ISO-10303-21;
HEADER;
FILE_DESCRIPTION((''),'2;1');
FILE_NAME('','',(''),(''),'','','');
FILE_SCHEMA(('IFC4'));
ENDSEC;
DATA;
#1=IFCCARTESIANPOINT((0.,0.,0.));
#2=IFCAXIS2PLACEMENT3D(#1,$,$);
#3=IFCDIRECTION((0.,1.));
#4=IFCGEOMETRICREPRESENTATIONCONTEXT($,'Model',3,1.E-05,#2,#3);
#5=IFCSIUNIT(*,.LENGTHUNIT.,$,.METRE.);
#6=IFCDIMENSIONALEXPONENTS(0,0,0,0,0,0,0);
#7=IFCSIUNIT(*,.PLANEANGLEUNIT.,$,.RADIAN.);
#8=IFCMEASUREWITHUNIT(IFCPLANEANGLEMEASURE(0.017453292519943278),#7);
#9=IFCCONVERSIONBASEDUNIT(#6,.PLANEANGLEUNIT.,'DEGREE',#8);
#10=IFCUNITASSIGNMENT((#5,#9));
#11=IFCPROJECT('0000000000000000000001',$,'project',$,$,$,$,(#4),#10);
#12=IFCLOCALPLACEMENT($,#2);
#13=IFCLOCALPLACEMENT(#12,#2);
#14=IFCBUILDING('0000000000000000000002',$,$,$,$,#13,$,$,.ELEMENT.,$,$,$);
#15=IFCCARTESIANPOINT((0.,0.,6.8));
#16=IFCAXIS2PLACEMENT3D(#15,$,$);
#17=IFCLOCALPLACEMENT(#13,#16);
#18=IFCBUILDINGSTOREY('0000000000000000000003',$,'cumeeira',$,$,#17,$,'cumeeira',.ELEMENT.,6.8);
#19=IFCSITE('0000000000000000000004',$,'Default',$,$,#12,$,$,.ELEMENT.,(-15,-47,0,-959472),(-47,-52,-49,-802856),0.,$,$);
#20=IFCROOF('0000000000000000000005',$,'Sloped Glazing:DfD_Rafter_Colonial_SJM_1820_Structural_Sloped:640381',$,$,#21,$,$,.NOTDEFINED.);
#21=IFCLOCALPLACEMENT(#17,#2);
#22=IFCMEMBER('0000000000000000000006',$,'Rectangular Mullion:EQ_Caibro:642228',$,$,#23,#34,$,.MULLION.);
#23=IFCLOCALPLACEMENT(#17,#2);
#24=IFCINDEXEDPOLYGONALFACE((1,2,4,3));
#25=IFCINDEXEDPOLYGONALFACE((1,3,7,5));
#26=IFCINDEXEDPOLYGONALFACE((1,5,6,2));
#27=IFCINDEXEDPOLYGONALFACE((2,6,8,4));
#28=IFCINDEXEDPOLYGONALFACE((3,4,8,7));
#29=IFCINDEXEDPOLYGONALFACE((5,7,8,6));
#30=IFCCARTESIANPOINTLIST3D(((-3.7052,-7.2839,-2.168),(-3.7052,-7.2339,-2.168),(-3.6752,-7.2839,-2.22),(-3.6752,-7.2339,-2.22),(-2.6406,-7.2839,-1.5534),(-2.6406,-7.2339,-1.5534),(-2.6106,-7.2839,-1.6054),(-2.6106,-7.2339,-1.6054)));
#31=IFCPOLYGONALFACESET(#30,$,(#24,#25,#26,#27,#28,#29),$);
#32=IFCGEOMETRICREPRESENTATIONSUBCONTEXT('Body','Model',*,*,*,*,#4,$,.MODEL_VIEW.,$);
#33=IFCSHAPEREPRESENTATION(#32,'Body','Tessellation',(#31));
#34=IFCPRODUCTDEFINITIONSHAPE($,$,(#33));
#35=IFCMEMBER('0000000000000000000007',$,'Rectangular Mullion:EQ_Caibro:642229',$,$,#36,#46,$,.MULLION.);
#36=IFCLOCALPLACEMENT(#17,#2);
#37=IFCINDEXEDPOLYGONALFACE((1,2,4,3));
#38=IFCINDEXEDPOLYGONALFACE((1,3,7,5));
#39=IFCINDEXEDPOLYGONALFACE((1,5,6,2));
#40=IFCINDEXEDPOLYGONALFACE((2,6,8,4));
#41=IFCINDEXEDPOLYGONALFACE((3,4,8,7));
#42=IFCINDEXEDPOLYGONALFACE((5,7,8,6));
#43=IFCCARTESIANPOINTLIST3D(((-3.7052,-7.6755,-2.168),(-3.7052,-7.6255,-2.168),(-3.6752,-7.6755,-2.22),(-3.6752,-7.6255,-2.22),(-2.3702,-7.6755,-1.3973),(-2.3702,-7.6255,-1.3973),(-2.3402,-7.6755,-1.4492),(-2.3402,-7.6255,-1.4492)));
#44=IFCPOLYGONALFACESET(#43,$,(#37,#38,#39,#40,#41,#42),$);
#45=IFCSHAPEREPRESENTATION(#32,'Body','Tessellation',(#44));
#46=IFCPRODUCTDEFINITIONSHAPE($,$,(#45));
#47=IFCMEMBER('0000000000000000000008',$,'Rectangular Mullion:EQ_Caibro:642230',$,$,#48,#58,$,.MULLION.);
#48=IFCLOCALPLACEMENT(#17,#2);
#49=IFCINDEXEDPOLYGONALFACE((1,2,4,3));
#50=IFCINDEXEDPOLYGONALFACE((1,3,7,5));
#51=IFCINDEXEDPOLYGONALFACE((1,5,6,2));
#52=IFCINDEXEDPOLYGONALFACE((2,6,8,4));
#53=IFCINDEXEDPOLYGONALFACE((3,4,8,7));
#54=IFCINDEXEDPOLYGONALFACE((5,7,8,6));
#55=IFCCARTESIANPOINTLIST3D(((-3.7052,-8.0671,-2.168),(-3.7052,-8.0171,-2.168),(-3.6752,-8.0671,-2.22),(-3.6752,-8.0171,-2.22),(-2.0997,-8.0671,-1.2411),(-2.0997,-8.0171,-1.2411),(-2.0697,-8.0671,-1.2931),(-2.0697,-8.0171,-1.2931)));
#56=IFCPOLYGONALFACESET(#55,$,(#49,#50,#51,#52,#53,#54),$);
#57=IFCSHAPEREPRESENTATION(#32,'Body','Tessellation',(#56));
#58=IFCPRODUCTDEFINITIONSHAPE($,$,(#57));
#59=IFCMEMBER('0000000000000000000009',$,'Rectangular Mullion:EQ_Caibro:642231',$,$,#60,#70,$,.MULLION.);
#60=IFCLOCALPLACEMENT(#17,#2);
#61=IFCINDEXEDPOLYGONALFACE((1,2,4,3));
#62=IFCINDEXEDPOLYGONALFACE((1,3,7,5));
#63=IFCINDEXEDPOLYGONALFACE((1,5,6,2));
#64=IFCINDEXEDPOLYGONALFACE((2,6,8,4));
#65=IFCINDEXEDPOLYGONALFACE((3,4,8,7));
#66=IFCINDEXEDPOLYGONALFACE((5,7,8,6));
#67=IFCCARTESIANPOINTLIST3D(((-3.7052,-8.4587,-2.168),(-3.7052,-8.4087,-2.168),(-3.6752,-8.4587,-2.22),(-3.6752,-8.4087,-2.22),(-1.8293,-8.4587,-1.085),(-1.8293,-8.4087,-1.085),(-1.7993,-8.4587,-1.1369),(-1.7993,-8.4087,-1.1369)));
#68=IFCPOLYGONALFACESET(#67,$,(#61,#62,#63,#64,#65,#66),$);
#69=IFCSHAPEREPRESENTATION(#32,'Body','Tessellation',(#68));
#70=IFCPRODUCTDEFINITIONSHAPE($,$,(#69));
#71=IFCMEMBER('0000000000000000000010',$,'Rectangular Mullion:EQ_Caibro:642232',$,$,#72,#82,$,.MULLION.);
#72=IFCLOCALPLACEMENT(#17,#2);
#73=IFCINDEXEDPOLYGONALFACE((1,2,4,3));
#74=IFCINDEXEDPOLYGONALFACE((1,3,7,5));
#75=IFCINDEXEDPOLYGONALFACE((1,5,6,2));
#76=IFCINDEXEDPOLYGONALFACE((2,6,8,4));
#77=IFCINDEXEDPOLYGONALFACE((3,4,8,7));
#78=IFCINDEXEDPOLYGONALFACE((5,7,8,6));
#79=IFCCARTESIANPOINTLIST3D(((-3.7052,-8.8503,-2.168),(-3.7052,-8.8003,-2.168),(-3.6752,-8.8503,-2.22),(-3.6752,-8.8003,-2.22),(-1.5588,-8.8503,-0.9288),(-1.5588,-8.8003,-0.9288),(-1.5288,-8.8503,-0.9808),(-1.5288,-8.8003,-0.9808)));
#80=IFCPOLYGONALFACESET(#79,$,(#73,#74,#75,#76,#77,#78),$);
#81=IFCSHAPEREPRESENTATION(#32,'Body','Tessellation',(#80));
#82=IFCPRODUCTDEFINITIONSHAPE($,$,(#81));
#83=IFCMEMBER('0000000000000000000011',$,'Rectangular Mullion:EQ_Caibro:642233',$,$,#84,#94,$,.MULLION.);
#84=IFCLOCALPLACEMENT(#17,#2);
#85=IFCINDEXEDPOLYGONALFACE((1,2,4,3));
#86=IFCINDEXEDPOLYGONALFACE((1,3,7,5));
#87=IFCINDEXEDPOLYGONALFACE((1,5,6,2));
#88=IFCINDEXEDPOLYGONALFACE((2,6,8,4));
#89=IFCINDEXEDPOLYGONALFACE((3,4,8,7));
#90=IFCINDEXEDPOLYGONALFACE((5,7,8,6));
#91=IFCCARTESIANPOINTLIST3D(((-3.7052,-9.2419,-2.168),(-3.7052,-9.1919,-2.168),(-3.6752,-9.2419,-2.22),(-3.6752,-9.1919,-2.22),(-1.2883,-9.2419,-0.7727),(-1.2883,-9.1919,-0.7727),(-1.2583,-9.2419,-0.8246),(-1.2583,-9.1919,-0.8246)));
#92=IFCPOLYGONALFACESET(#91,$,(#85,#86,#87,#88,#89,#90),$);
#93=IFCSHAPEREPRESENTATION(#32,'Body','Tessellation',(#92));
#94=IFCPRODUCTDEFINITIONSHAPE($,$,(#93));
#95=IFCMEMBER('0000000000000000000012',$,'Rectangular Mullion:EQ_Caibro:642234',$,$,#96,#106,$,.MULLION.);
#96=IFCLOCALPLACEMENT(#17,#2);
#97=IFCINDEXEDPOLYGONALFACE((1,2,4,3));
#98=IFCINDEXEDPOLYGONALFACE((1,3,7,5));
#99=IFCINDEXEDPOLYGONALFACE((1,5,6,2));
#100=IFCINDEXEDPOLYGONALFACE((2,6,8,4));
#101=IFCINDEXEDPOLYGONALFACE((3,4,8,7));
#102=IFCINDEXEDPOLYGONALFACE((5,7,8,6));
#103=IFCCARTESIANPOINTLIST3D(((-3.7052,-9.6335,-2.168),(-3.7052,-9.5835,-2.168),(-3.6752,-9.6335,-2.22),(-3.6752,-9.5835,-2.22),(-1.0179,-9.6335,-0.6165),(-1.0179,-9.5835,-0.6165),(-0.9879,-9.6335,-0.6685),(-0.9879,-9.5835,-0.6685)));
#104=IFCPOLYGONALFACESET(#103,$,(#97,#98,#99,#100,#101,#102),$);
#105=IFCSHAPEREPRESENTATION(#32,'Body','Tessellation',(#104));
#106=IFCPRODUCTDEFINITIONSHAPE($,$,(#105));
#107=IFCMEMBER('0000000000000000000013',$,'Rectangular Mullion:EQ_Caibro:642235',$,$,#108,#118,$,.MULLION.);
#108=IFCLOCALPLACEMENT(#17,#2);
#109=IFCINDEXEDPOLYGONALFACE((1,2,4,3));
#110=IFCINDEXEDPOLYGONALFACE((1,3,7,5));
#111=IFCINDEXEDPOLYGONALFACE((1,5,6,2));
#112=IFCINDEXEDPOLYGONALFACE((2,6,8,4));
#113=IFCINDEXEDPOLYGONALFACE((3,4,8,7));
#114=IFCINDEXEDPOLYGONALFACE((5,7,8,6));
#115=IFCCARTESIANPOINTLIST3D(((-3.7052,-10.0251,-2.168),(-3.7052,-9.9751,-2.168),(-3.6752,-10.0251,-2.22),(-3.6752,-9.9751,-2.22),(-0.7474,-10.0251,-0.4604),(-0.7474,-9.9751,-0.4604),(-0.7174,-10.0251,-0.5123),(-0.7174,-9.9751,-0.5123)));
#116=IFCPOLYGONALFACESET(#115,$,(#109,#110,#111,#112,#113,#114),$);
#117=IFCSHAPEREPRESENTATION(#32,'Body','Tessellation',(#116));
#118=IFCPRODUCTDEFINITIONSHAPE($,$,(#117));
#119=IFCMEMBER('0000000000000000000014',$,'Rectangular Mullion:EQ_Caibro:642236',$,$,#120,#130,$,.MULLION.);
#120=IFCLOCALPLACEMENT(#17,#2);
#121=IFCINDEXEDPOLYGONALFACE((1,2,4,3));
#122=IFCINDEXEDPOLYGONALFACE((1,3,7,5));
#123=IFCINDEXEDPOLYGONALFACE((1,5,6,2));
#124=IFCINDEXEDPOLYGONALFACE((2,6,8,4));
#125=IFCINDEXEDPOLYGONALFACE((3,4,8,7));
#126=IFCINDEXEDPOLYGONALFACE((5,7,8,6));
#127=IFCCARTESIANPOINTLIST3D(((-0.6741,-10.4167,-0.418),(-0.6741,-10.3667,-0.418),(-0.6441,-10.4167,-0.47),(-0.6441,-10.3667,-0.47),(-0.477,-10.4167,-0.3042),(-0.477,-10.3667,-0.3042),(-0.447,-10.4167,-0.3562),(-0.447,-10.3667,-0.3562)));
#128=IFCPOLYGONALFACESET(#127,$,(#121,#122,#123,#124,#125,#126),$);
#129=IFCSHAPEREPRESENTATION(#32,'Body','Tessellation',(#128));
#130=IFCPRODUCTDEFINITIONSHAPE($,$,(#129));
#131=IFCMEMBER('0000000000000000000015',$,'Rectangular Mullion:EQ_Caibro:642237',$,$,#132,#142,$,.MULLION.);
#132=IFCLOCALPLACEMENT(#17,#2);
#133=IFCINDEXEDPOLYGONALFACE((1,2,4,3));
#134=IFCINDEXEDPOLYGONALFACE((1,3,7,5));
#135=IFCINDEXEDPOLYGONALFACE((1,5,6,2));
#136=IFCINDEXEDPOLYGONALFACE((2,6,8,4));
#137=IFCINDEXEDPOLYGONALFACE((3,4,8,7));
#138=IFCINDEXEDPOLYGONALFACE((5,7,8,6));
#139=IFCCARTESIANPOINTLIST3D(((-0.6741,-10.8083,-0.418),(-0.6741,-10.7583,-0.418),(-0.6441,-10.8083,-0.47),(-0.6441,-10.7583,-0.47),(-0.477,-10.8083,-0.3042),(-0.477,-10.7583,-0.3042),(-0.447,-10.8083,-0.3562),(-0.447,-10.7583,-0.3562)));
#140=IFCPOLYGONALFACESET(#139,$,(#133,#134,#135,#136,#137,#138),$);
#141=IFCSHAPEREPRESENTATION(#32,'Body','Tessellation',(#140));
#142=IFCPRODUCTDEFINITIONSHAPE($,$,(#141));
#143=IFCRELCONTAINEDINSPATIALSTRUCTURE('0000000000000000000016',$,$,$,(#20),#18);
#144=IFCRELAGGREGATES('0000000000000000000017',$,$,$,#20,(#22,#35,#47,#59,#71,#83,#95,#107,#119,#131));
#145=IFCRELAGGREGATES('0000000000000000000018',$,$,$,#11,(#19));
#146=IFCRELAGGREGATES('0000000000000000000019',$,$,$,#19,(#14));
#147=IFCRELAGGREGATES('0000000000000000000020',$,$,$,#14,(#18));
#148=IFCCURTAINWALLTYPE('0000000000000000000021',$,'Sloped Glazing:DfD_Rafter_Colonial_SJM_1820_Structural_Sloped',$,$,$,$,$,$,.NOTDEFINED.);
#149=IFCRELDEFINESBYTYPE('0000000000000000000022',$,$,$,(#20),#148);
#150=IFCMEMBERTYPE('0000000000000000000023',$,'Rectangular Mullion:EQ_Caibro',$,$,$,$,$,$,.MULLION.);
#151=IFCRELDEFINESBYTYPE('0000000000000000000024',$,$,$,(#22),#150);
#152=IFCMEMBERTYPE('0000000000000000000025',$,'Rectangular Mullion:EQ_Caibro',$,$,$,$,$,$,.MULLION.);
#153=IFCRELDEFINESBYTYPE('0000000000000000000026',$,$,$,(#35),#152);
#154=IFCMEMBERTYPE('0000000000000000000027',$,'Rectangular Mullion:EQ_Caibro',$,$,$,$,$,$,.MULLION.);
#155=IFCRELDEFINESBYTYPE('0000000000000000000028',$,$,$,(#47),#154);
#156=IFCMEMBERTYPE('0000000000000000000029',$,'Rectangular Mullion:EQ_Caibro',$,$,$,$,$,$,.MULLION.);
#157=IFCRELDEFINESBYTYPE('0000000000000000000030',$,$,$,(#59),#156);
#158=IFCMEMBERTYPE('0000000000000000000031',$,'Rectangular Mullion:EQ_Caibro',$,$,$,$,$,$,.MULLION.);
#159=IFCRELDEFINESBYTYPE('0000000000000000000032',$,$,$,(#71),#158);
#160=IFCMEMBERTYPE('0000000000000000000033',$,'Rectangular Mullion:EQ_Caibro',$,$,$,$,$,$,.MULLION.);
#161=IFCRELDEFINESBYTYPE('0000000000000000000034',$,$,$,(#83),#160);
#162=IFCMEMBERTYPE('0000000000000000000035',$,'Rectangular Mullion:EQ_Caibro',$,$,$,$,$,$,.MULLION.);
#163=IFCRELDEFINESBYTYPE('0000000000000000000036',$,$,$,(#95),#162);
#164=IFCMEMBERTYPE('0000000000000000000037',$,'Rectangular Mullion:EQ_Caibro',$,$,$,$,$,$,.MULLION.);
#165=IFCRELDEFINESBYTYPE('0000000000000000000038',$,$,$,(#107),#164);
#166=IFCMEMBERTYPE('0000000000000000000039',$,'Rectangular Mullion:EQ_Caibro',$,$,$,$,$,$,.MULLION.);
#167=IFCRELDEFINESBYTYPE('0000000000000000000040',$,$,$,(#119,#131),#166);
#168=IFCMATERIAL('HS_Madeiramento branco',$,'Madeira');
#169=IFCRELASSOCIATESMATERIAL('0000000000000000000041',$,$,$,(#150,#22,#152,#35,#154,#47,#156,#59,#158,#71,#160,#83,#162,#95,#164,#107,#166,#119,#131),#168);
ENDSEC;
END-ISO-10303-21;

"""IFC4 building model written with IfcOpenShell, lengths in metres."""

from ifc_helpers import new_model, entity, si_unit, converted_unit, direction, frame, origin, place, context, subcontext, project, spatial, indexed_curve, outline, extrude, source, transform, mapped, material, type_object, type_shapes, element, aggregate, save


model = new_model("IFC4")

# Units and contexts
model_context = context("Model", 3, precision=1e-05, world=origin(), true_north=direction((0.0, 1.0)))
body_context = subcontext(model_context, "Body", "Model", "MODEL_VIEW")
ifc_project = project(units=[si_unit("LENGTHUNIT", "METRE"), converted_unit("PLANEANGLEUNIT", "DEGREE", entity("IfcPlaneAngleMeasure", 0.017453292519943278), si_unit("PLANEANGLEUNIT", "RADIAN"), dimensions=[0, 0, 0, 0, 0, 0, 0])], contexts=[model_context])

# Site, building, storey
site_placement = place(None, origin())
site = spatial("IfcSite", under=ifc_project, at=site_placement, Name="Default", CompositionType="ELEMENT", RefLatitude=(-15, -47, 0, -959472), RefLongitude=(-47, -52, -49, -802856), RefElevation=0.0)
building_placement = place(site_placement, origin())
building = spatial("IfcBuilding", under=site, at=building_placement, CompositionType="ELEMENT")
storey_placement = place(building_placement, frame((0.0, 0.0, 6.8)))
storey = spatial("IfcBuildingStorey", under=building, at=storey_placement, Name="cumeeira", LongName="cumeeira", CompositionType="ELEMENT", Elevation=6.8)

# Roof, members
curtain_wall_type = type_object("IfcCurtainWallType", Name="Sloped Glazing:DfD_Rafter_Colonial_SJM_1820_Structural_Sloped", PredefinedType="NOTDEFINED")
roof_placement = place(storey_placement, frame((0.0, 0.0, -6.8)))
roof = element("IfcRoof", 1, at=roof_placement, inside=storey, type_object=curtain_wall_type, Name="Sloped Glazing:DfD_Rafter_Colonial_SJM_1820_Structural_Sloped:640381", PredefinedType="NOTDEFINED")
ifc_material = material(Name="HS_Madeiramento branco", Category="Madeira")
member_type_1 = type_object("IfcMemberType", Name="Rectangular Mullion:EQ_Caibro", PredefinedType="MULLION", material=ifc_material)
shared_shape_1 = source(origin(), body_context, "Body", "SweptSolid", [
    extrude(outline(indexed_curve([(-0.025, -0.03), (0.025, -0.03), (0.025, 0.03), (-0.025, 0.03), (-0.025, -0.03)], self_intersect=False)), frame((0.0, -0.03, -1.2293), z_axis=(0.0, 0.0, 1.0), x_axis=(-1.0, 0.0, 0.0)), (0.0, 0.0, 1.0), 1.2293),
])
type_shapes(member_type_1, [shared_shape_1])
member_1_placement = place(roof_placement, frame((-2.6106, -7.2589, 5.1946), z_axis=(0.866025, 0.0, 0.5), x_axis=(0.0, -1.0, 0.0)))
member_1 = element("IfcMember", 2, at=member_1_placement, type_object=member_type_1, material=ifc_material, Name="Rectangular Mullion:EQ_Caibro:642228", PredefinedType="MULLION", context=body_context, shape_type="MappedRepresentation", body=[
    mapped(shared_shape_1, transform((0.0, 0.0, 0.0), scale=1.0)),
])
member_type_2 = type_object("IfcMemberType", Name="Rectangular Mullion:EQ_Caibro", PredefinedType="MULLION", material=ifc_material)
shared_shape_2 = source(origin(), body_context, "Body", "SweptSolid", [
    extrude(outline(indexed_curve([(-0.025, -0.03), (0.025, -0.03), (0.025, 0.03), (-0.025, 0.03), (-0.025, -0.03)], self_intersect=False)), frame((0.0, -0.03, -1.5415), z_axis=(0.0, 0.0, 1.0), x_axis=(-1.0, 0.0, 0.0)), (0.0, 0.0, 1.0), 1.5415),
])
type_shapes(member_type_2, [shared_shape_2])
member_2_placement = place(roof_placement, frame((-2.3402, -7.6505, 5.3508), z_axis=(0.866025, 0.0, 0.5), x_axis=(0.0, -1.0, 0.0)))
member_2 = element("IfcMember", 3, at=member_2_placement, type_object=member_type_2, material=ifc_material, Name="Rectangular Mullion:EQ_Caibro:642229", PredefinedType="MULLION", context=body_context, shape_type="MappedRepresentation", body=[
    mapped(shared_shape_2, transform((0.0, 0.0, 0.0), scale=1.0)),
])
member_type_3 = type_object("IfcMemberType", Name="Rectangular Mullion:EQ_Caibro", PredefinedType="MULLION", material=ifc_material)
shared_shape_3 = source(origin(), body_context, "Body", "SweptSolid", [
    extrude(outline(indexed_curve([(-0.025, -0.03), (0.025, -0.03), (0.025, 0.03), (-0.025, 0.03), (-0.025, -0.03)], self_intersect=False)), frame((0.0, -0.03, -1.8538), z_axis=(0.0, 0.0, 1.0), x_axis=(-1.0, 0.0, 0.0)), (0.0, 0.0, 1.0), 1.8538),
])
type_shapes(member_type_3, [shared_shape_3])
member_3_placement = place(roof_placement, frame((-2.0697, -8.0421, 5.5069), z_axis=(0.866025, 0.0, 0.5), x_axis=(0.0, -1.0, 0.0)))
member_3 = element("IfcMember", 4, at=member_3_placement, type_object=member_type_3, material=ifc_material, Name="Rectangular Mullion:EQ_Caibro:642230", PredefinedType="MULLION", context=body_context, shape_type="MappedRepresentation", body=[
    mapped(shared_shape_3, transform((0.0, 0.0, 0.0), scale=1.0)),
])
member_type_4 = type_object("IfcMemberType", Name="Rectangular Mullion:EQ_Caibro", PredefinedType="MULLION", material=ifc_material)
shared_shape_4 = source(origin(), body_context, "Body", "SweptSolid", [
    extrude(outline(indexed_curve([(-0.025, -0.03), (0.025, -0.03), (0.025, 0.03), (-0.025, 0.03), (-0.025, -0.03)], self_intersect=False)), frame((0.0, -0.03, -2.1661), z_axis=(0.0, 0.0, 1.0), x_axis=(-1.0, 0.0, 0.0)), (0.0, 0.0, 1.0), 2.1661),
])
type_shapes(member_type_4, [shared_shape_4])
member_4_placement = place(roof_placement, frame((-1.7993, -8.4337, 5.6631), z_axis=(0.866025, 0.0, 0.5), x_axis=(0.0, -1.0, 0.0)))
member_4 = element("IfcMember", 5, at=member_4_placement, type_object=member_type_4, material=ifc_material, Name="Rectangular Mullion:EQ_Caibro:642231", PredefinedType="MULLION", context=body_context, shape_type="MappedRepresentation", body=[
    mapped(shared_shape_4, transform((0.0, 0.0, 0.0), scale=1.0)),
])
member_type_5 = type_object("IfcMemberType", Name="Rectangular Mullion:EQ_Caibro", PredefinedType="MULLION", material=ifc_material)
shared_shape_5 = source(origin(), body_context, "Body", "SweptSolid", [
    extrude(outline(indexed_curve([(-0.025, -0.03), (0.025, -0.03), (0.025, 0.03), (-0.025, 0.03), (-0.025, -0.03)], self_intersect=False)), frame((0.0, -0.03, -2.4784), z_axis=(0.0, 0.0, 1.0), x_axis=(-1.0, 0.0, 0.0)), (0.0, 0.0, 1.0), 2.4784),
])
type_shapes(member_type_5, [shared_shape_5])
member_5_placement = place(roof_placement, frame((-1.5288, -8.8253, 5.8192), z_axis=(0.866025, 0.0, 0.5), x_axis=(0.0, -1.0, 0.0)))
member_5 = element("IfcMember", 6, at=member_5_placement, type_object=member_type_5, material=ifc_material, Name="Rectangular Mullion:EQ_Caibro:642232", PredefinedType="MULLION", context=body_context, shape_type="MappedRepresentation", body=[
    mapped(shared_shape_5, transform((0.0, 0.0, 0.0), scale=1.0)),
])
member_type_6 = type_object("IfcMemberType", Name="Rectangular Mullion:EQ_Caibro", PredefinedType="MULLION", material=ifc_material)
shared_shape_6 = source(origin(), body_context, "Body", "SweptSolid", [
    extrude(outline(indexed_curve([(-0.025, -0.03), (0.025, -0.03), (0.025, 0.03), (-0.025, 0.03), (-0.025, -0.03)], self_intersect=False)), frame((0.0, -0.03, -2.7907), z_axis=(0.0, 0.0, 1.0), x_axis=(-1.0, 0.0, 0.0)), (0.0, 0.0, 1.0), 2.7907),
])
type_shapes(member_type_6, [shared_shape_6])
member_6_placement = place(roof_placement, frame((-1.2583, -9.2169, 5.9754), z_axis=(0.866025, 0.0, 0.5), x_axis=(0.0, -1.0, 0.0)))
member_6 = element("IfcMember", 7, at=member_6_placement, type_object=member_type_6, material=ifc_material, Name="Rectangular Mullion:EQ_Caibro:642233", PredefinedType="MULLION", context=body_context, shape_type="MappedRepresentation", body=[
    mapped(shared_shape_6, transform((0.0, 0.0, 0.0), scale=1.0)),
])
member_type_7 = type_object("IfcMemberType", Name="Rectangular Mullion:EQ_Caibro", PredefinedType="MULLION", material=ifc_material)
shared_shape_7 = source(origin(), body_context, "Body", "SweptSolid", [
    extrude(outline(indexed_curve([(-0.025, -0.03), (0.025, -0.03), (0.025, 0.03), (-0.025, 0.03), (-0.025, -0.03)], self_intersect=False)), frame((0.0, -0.03, -3.103), z_axis=(0.0, 0.0, 1.0), x_axis=(-1.0, 0.0, 0.0)), (0.0, 0.0, 1.0), 3.103),
])
type_shapes(member_type_7, [shared_shape_7])
member_7_placement = place(roof_placement, frame((-0.9879, -9.6085, 6.1315), z_axis=(0.866025, 0.0, 0.5), x_axis=(0.0, -1.0, 0.0)))
member_7 = element("IfcMember", 8, at=member_7_placement, type_object=member_type_7, material=ifc_material, Name="Rectangular Mullion:EQ_Caibro:642234", PredefinedType="MULLION", context=body_context, shape_type="MappedRepresentation", body=[
    mapped(shared_shape_7, transform((0.0, 0.0, 0.0), scale=1.0)),
])
member_type_8 = type_object("IfcMemberType", Name="Rectangular Mullion:EQ_Caibro", PredefinedType="MULLION", material=ifc_material)
shared_shape_8 = source(origin(), body_context, "Body", "SweptSolid", [
    extrude(outline(indexed_curve([(-0.025, -0.03), (0.025, -0.03), (0.025, 0.03), (-0.025, 0.03), (-0.025, -0.03)], self_intersect=False)), frame((0.0, -0.03, -3.4153), z_axis=(0.0, 0.0, 1.0), x_axis=(-1.0, 0.0, 0.0)), (0.0, 0.0, 1.0), 3.4153),
])
type_shapes(member_type_8, [shared_shape_8])
member_8_placement = place(roof_placement, frame((-0.7174, -10.0001, 6.2877), z_axis=(0.866025, 0.0, 0.5), x_axis=(0.0, -1.0, 0.0)))
member_8 = element("IfcMember", 9, at=member_8_placement, type_object=member_type_8, material=ifc_material, Name="Rectangular Mullion:EQ_Caibro:642235", PredefinedType="MULLION", context=body_context, shape_type="MappedRepresentation", body=[
    mapped(shared_shape_8, transform((0.0, 0.0, 0.0), scale=1.0)),
])
member_type_9 = type_object("IfcMemberType", Name="Rectangular Mullion:EQ_Caibro", PredefinedType="MULLION", material=ifc_material)
shared_shape_9 = source(origin(), body_context, "Body", "SweptSolid", [
    extrude(outline(indexed_curve([(-0.025, -0.03), (0.025, -0.03), (0.025, 0.03), (-0.025, 0.03), (-0.025, -0.03)], self_intersect=False)), frame((0.0, -0.03, -0.2276), z_axis=(0.0, 0.0, 1.0), x_axis=(-1.0, 0.0, 0.0)), (0.0, 0.0, 1.0), 0.2276),
])
type_shapes(member_type_9, [shared_shape_9])
member_9_placement = place(roof_placement, frame((-0.447, -10.3917, 6.4438), z_axis=(0.866025, 0.0, 0.5), x_axis=(0.0, -1.0, 0.0)))
member_9 = element("IfcMember", 10, at=member_9_placement, type_object=member_type_9, material=ifc_material, Name="Rectangular Mullion:EQ_Caibro:642236", PredefinedType="MULLION", context=body_context, shape_type="MappedRepresentation", body=[
    mapped(shared_shape_9, transform((0.0, 0.0, 0.0), scale=1.0)),
])
member_10_placement = place(roof_placement, frame((-0.447, -10.7833, 6.4438), z_axis=(0.866025, 0.0, 0.5), x_axis=(0.0, -1.0, 0.0)))
member_10 = element("IfcMember", 11, at=member_10_placement, type_object=member_type_9, material=ifc_material, Name="Rectangular Mullion:EQ_Caibro:642237", PredefinedType="MULLION", context=body_context, shape_type="MappedRepresentation", body=[
    mapped(shared_shape_9, transform((0.0, 0.0, 0.0), scale=1.0)),
])
aggregate(roof, [member_1, member_2, member_3, member_4, member_5, member_6, member_7, member_8, member_9, member_10])

save(model, "model.ifc")
